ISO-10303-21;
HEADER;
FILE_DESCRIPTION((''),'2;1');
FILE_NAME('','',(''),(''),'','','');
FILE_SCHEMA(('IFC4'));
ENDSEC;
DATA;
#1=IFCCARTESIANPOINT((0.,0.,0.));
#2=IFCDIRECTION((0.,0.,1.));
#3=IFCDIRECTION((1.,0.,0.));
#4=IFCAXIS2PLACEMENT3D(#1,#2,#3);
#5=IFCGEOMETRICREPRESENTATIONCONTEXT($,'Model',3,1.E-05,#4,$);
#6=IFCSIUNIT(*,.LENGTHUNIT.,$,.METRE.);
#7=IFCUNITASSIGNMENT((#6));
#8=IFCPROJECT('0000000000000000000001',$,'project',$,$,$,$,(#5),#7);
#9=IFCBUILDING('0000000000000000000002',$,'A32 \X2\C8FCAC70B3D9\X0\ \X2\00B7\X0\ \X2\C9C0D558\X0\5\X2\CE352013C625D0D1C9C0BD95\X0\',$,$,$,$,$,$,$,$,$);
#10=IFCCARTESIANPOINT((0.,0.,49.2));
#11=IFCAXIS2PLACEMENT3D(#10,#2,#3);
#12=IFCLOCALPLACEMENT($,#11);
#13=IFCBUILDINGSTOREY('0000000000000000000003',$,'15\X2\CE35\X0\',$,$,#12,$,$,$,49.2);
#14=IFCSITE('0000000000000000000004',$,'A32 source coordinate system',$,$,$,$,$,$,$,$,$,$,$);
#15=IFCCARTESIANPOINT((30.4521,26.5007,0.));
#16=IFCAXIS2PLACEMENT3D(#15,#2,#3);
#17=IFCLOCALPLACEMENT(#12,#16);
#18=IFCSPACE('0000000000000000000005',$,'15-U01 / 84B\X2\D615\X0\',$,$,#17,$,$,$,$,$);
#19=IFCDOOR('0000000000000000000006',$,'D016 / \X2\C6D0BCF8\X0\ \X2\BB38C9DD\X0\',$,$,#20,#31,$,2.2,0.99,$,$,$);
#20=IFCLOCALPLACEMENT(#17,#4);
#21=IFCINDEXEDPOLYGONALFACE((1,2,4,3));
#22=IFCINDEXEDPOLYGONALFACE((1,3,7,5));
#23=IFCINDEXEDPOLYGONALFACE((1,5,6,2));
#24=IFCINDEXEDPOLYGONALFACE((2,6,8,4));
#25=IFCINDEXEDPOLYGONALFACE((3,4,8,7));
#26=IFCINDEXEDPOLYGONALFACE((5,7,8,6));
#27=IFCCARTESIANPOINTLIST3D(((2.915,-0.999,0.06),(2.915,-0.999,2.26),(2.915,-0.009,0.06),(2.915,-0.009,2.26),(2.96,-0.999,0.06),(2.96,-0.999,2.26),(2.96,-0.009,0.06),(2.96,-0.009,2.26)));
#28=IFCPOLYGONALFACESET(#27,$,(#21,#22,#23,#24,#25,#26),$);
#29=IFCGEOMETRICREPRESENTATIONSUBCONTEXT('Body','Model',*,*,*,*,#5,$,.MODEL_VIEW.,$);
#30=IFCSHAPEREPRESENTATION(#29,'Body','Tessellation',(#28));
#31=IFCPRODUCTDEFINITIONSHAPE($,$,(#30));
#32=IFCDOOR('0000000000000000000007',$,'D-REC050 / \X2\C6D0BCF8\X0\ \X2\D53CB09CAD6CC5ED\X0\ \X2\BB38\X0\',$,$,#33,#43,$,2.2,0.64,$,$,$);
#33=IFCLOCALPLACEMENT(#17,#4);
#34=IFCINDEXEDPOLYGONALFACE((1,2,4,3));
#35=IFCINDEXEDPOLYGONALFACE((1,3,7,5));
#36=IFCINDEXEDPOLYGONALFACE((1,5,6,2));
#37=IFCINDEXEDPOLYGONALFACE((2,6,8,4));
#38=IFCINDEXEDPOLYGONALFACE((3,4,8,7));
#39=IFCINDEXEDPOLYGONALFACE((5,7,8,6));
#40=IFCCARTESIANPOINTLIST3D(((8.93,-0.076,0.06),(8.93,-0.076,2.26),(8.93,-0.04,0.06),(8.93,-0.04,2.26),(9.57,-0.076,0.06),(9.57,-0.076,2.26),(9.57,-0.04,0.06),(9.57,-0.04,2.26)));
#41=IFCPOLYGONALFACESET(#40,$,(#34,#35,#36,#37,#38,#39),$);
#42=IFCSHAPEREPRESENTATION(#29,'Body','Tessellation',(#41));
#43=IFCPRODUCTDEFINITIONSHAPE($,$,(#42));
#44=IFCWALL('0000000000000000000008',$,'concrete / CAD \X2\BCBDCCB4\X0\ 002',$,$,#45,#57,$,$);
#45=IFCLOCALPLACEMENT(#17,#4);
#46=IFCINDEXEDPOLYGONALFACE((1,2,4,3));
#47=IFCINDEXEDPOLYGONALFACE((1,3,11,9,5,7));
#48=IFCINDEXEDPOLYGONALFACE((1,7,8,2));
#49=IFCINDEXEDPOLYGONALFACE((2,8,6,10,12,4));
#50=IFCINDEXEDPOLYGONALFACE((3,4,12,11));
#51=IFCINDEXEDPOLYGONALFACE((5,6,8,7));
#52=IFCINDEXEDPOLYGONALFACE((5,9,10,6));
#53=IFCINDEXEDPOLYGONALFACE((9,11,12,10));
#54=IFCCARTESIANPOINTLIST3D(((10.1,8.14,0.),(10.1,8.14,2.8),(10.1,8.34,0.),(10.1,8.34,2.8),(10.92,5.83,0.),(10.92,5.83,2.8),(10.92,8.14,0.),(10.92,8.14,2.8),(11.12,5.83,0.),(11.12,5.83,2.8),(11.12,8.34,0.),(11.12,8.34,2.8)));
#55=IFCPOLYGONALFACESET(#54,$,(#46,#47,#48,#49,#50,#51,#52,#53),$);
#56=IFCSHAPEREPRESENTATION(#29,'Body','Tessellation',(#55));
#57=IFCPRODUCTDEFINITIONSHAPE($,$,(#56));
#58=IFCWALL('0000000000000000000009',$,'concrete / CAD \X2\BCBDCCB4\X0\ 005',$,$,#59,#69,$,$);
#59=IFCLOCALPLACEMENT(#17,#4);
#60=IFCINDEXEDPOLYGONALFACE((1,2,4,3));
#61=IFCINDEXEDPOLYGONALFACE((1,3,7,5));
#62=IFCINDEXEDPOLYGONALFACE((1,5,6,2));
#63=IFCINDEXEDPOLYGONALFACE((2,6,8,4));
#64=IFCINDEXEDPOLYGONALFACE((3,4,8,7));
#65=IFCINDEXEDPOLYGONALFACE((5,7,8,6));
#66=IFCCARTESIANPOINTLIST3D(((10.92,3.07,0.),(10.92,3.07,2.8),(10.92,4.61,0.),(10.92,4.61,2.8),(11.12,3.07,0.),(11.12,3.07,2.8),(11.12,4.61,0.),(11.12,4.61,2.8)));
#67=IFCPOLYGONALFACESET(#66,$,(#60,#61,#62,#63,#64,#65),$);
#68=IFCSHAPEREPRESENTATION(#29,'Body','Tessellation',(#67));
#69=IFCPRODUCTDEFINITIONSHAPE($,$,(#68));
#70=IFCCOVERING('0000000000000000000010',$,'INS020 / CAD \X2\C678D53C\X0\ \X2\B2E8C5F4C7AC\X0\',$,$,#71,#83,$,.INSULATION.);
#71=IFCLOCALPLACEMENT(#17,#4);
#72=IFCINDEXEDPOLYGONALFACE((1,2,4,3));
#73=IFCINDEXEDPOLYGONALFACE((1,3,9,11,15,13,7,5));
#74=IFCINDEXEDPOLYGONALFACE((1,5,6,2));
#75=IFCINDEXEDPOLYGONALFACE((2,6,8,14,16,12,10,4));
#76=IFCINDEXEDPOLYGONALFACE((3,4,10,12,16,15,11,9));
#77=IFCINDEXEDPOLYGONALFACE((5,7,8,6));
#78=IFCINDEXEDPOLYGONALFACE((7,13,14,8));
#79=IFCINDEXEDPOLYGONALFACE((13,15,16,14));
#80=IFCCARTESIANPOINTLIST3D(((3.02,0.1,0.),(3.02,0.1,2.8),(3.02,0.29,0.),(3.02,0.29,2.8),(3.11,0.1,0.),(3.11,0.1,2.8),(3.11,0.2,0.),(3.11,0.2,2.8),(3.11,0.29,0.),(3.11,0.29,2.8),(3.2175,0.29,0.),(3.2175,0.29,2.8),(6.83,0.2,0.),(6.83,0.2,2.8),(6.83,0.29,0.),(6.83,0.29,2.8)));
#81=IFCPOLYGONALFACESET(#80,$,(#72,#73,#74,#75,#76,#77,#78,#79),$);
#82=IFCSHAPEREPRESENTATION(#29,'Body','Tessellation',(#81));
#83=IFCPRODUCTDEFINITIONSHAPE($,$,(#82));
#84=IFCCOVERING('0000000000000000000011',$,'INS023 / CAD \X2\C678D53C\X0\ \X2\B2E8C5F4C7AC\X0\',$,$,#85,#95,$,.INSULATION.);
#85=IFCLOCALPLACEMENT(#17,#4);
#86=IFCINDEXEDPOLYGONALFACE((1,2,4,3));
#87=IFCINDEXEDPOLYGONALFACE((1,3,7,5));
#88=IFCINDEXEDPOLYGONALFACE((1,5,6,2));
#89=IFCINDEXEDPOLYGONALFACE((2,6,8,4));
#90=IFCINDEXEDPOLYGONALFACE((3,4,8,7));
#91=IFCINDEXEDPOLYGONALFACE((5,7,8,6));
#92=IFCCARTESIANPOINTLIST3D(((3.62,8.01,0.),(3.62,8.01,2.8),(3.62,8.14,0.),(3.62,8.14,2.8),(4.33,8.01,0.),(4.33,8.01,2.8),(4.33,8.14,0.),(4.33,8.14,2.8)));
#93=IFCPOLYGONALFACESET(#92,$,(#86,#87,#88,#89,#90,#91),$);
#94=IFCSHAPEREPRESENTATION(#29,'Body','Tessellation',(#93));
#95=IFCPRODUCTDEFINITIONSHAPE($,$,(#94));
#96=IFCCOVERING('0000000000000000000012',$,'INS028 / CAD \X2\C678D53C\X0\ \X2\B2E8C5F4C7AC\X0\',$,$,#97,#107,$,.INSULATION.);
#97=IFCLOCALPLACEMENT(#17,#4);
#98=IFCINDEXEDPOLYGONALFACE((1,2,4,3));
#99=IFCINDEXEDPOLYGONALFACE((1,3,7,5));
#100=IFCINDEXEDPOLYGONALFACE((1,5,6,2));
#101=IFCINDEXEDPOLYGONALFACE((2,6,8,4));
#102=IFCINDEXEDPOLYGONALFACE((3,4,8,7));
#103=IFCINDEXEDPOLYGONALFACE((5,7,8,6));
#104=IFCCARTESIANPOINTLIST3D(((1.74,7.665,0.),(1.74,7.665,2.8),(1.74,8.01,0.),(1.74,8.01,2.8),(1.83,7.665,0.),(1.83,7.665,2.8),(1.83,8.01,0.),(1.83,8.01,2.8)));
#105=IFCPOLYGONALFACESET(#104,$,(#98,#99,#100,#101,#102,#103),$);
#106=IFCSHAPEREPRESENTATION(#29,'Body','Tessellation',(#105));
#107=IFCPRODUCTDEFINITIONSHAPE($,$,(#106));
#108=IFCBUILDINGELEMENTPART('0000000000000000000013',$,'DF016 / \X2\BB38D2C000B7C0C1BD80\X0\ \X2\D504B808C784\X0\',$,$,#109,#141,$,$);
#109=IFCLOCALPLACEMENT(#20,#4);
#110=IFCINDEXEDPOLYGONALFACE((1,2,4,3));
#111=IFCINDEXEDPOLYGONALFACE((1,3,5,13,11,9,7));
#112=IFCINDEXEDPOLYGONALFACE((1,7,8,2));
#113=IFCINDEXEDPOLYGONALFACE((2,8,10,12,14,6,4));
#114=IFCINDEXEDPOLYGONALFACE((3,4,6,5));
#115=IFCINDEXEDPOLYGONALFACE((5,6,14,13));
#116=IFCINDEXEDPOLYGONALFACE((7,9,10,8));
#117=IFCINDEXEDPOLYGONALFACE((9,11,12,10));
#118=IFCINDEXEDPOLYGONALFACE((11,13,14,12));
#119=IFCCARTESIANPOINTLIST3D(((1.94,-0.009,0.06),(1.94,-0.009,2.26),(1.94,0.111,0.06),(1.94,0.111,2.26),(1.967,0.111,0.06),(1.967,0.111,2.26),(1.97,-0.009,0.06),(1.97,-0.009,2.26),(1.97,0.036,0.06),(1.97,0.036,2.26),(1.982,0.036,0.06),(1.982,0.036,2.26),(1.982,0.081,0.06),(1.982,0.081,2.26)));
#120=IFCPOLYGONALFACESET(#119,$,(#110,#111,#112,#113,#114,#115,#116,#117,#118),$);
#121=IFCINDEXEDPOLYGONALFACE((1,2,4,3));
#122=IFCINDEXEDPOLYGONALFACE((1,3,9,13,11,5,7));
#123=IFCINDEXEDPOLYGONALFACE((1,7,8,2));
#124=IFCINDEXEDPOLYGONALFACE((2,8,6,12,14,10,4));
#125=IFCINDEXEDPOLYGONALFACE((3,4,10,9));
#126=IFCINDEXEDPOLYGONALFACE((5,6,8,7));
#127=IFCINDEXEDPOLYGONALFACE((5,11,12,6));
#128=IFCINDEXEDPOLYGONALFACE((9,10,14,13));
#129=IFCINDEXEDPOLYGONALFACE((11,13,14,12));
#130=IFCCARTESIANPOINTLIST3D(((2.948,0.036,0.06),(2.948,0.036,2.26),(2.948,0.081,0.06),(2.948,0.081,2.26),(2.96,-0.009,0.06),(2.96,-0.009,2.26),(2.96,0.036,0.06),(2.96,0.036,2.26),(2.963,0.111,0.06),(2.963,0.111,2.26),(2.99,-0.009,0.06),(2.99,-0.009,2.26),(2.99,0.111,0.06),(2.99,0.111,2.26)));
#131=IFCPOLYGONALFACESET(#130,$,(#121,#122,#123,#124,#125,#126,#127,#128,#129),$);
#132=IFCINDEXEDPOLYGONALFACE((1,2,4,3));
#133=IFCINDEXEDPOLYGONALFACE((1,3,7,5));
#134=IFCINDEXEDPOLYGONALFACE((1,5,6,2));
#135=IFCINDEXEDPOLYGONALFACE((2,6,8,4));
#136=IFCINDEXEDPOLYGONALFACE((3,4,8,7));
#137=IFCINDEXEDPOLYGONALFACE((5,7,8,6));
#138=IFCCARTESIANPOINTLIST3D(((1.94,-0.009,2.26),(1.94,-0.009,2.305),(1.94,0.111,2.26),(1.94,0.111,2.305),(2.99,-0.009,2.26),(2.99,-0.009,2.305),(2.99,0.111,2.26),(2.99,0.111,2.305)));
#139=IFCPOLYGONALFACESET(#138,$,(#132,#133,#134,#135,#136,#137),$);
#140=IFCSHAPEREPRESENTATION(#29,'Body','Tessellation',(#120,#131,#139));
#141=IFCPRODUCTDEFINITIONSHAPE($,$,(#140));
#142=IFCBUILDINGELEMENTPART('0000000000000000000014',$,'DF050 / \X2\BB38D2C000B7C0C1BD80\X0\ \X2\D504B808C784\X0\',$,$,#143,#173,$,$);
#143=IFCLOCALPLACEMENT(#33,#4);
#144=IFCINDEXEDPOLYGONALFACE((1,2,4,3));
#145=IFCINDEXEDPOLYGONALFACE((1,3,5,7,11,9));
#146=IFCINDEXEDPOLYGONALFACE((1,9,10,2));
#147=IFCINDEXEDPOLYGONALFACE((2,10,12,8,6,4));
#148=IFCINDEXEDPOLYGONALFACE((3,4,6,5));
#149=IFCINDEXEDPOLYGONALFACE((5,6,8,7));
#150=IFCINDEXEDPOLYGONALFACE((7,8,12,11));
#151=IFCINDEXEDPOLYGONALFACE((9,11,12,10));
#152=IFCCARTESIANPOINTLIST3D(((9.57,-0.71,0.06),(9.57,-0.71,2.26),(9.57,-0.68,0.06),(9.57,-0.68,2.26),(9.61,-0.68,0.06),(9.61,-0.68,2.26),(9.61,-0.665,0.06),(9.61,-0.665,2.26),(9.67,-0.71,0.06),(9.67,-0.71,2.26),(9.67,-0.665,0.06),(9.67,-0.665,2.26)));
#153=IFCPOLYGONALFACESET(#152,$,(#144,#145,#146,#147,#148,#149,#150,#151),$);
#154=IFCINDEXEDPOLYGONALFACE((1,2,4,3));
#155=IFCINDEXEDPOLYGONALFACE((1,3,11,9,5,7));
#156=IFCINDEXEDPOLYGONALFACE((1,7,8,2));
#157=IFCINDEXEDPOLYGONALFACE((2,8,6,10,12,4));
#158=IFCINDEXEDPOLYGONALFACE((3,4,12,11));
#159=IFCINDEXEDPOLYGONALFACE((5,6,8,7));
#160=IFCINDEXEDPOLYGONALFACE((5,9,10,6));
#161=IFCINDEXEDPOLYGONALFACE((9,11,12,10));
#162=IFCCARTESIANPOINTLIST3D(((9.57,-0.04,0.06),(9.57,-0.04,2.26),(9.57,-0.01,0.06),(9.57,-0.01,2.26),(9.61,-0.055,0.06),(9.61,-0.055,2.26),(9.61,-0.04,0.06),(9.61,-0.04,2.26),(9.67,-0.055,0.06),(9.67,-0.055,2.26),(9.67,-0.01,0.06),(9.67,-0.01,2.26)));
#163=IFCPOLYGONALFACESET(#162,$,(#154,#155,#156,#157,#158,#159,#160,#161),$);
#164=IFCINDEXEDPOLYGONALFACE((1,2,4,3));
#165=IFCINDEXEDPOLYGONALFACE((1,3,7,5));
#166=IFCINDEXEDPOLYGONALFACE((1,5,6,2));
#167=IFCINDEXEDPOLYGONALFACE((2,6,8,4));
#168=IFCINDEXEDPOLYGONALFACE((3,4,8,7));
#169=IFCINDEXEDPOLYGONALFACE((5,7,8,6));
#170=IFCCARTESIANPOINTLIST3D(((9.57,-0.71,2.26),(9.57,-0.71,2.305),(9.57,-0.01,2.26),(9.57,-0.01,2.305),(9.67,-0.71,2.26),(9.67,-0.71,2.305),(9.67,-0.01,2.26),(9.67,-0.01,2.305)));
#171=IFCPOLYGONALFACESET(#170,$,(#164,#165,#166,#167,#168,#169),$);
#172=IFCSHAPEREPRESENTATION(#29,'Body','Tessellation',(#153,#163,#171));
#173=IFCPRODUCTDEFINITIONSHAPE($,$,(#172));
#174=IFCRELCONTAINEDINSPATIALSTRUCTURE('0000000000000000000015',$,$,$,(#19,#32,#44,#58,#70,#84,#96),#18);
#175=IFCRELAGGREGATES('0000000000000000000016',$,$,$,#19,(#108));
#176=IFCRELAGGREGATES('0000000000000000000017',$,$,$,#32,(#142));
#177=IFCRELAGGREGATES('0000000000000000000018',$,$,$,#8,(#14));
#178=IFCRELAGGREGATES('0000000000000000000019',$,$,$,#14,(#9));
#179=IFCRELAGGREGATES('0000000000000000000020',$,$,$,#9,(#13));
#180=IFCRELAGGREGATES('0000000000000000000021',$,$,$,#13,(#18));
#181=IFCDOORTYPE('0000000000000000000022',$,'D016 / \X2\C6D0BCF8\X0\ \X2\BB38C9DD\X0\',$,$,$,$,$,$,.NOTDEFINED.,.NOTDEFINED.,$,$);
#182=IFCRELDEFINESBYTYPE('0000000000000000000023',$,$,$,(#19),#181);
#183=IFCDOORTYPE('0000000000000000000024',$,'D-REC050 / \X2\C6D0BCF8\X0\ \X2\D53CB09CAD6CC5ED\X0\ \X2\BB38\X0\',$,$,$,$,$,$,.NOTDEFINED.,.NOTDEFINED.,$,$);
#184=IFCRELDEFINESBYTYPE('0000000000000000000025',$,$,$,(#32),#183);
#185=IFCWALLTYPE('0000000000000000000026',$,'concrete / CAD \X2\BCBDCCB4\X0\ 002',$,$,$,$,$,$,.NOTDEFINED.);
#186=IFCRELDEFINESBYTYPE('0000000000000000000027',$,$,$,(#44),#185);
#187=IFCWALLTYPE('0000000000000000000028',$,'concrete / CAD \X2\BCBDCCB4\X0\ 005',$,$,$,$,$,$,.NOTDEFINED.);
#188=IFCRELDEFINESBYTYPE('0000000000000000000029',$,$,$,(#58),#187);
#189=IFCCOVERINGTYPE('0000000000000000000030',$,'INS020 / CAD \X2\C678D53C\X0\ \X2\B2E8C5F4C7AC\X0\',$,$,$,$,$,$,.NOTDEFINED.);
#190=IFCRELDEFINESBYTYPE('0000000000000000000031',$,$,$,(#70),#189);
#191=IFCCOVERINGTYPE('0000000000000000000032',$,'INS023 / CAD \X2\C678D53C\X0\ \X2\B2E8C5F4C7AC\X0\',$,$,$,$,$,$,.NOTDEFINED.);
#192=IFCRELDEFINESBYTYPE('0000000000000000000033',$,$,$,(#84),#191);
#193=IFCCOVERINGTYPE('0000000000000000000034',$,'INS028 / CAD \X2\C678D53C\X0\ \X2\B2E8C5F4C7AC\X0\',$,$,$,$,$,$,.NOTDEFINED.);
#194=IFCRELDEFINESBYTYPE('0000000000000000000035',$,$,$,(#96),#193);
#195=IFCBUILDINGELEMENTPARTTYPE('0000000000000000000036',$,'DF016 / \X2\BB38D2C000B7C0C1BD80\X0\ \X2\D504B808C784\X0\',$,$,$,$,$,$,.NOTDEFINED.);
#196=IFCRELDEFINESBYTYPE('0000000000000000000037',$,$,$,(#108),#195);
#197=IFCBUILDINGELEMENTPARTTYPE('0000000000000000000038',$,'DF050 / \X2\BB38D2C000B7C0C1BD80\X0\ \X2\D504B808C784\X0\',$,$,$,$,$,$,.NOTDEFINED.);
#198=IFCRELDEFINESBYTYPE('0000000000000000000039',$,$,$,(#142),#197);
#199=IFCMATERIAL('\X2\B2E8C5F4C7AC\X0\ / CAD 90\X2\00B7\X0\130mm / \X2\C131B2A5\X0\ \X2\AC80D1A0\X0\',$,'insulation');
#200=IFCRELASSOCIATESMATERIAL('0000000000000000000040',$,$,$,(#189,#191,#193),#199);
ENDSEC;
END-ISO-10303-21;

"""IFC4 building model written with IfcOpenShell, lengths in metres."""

from ifc_helpers import new_model, si_unit, frame, origin, origin_with_axes, place, context, subcontext, project, spatial, polyline, outline, extrude, source, transform, mapped, material, type_object, type_shapes, element, aggregate, save


model = new_model("IFC4")

# Units and contexts
model_context = context("Model", 3, precision=1e-05, world=origin_with_axes())
body_context = subcontext(model_context, "Body", "Model", "MODEL_VIEW")
ifc_project = project(units=[si_unit("LENGTHUNIT", "METRE")], contexts=[model_context])

# Site, building, storey, space
storey_placement = place(None, frame((0.0, 0.0, 49.2), z_axis=(0.0, 0.0, 1.0), x_axis=(1.0, 0.0, 0.0)))
space_placement = place(storey_placement, frame((30.4521, 26.5007, 0.0), z_axis=(0.0, 0.0, 1.0), x_axis=(1.0, 0.0, 0.0)))
site = spatial("IfcSite", under=ifc_project, Name="A32 source coordinate system")
building = spatial("IfcBuilding", under=site, Name="A32 주거동 · 지하5층–옥탑지붕")
storey = spatial("IfcBuildingStorey", under=building, at=storey_placement, Name="15층", Elevation=49.2)
space = spatial("IfcSpace", under=storey, at=space_placement, Name="15-U01 / 84B형")

# Doors
door_type_1 = type_object("IfcDoorType", Name="D016 / 원본 문짝", OperationType="NOTDEFINED", PredefinedType="NOTDEFINED")
shared_shape_1 = source(origin(), body_context, "Body", "SweptSolid", [
    extrude(outline(polyline([(2.96, -0.009), (2.96, -0.999), (2.915, -0.999), (2.915, -0.009), (2.96, -0.009)])), frame((0.0, 0.0, 0.06)), (0.0, 0.0, 1.0), 2.2),
])
type_shapes(door_type_1, [shared_shape_1])
door_1_placement = place(space_placement, origin_with_axes())
door_1 = element("IfcDoor", 1, at=door_1_placement, inside=space, type_object=door_type_1, Name="D016 / 원본 문짝", OverallHeight=2.2, OverallWidth=0.99, context=body_context, shape_type="MappedRepresentation", body=[
    mapped(shared_shape_1, transform((0.0, 0.0, 0.0), scale=1.0)),
])
door_type_2 = type_object("IfcDoorType", Name="D-REC050 / 원본 피난구역 문", OperationType="NOTDEFINED", PredefinedType="NOTDEFINED")
shared_shape_2 = source(origin(), body_context, "Body", "SweptSolid", [
    extrude(outline(polyline([(9.57, -0.04), (9.57, -0.076), (8.93, -0.076), (8.93, -0.04), (9.57, -0.04)])), frame((0.0, 0.0, 0.06)), (0.0, 0.0, 1.0), 2.2),
])
type_shapes(door_type_2, [shared_shape_2])
door_2_placement = place(space_placement, origin_with_axes())
door_2 = element("IfcDoor", 2, at=door_2_placement, inside=space, type_object=door_type_2, Name="D-REC050 / 원본 피난구역 문", OverallHeight=2.2, OverallWidth=0.64, context=body_context, shape_type="MappedRepresentation", body=[
    mapped(shared_shape_2, transform((0.0, 0.0, 0.0), scale=1.0)),
])

# Walls
wall_type_1 = type_object("IfcWallType", Name="concrete / CAD 벽체 002", PredefinedType="NOTDEFINED")
shared_shape_3 = source(origin(), body_context, "Body", "SweptSolid", [
    extrude(outline(polyline([(11.12, 5.83), (10.92, 5.83), (10.92, 8.14), (10.1, 8.14), (10.1, 8.34), (11.12, 8.34), (11.12, 5.83)])), origin(), (0.0, 0.0, 1.0), 2.8),
])
type_shapes(wall_type_1, [shared_shape_3])
wall_1_placement = place(space_placement, origin_with_axes())
element("IfcWall", 3, at=wall_1_placement, inside=space, type_object=wall_type_1, Name="concrete / CAD 벽체 002", context=body_context, shape_type="MappedRepresentation", body=[
    mapped(shared_shape_3, transform((0.0, 0.0, 0.0), scale=1.0)),
])
wall_type_2 = type_object("IfcWallType", Name="concrete / CAD 벽체 005", PredefinedType="NOTDEFINED")
shared_shape_4 = source(origin(), body_context, "Body", "SweptSolid", [
    extrude(outline(polyline([(11.12, 3.07), (10.92, 3.07), (10.92, 4.61), (11.12, 4.61), (11.12, 3.07)])), origin(), (0.0, 0.0, 1.0), 2.8),
])
type_shapes(wall_type_2, [shared_shape_4])
wall_2_placement = place(space_placement, origin_with_axes())
element("IfcWall", 4, at=wall_2_placement, inside=space, type_object=wall_type_2, Name="concrete / CAD 벽체 005", context=body_context, shape_type="MappedRepresentation", body=[
    mapped(shared_shape_4, transform((0.0, 0.0, 0.0), scale=1.0)),
])

# Coverings
ifc_material = material(Name="단열재 / CAD 90·130mm / 성능 검토", Category="insulation")
covering_type_1 = type_object("IfcCoveringType", Name="INS020 / CAD 외피 단열재", PredefinedType="NOTDEFINED", material=ifc_material)
shared_shape_5 = source(origin(), body_context, "Body", "SweptSolid", [
    extrude(outline(polyline([(3.11, 0.2), (3.11, 0.1), (3.02, 0.1), (3.02, 0.29), (3.11, 0.29), (3.2175, 0.29), (6.83, 0.29), (6.83, 0.2), (3.11, 0.2)])), origin(), (0.0, 0.0, 1.0), 2.8),
])
type_shapes(covering_type_1, [shared_shape_5])
covering_1_placement = place(space_placement, origin_with_axes())
element("IfcCovering", 5, at=covering_1_placement, inside=space, type_object=covering_type_1, Name="INS020 / CAD 외피 단열재", PredefinedType="INSULATION", context=body_context, shape_type="MappedRepresentation", body=[
    mapped(shared_shape_5, transform((0.0, 0.0, 0.0), scale=1.0)),
])
covering_type_2 = type_object("IfcCoveringType", Name="INS023 / CAD 외피 단열재", PredefinedType="NOTDEFINED", material=ifc_material)
shared_shape_6 = source(origin(), body_context, "Body", "SweptSolid", [
    extrude(outline(polyline([(4.33, 8.01), (3.62, 8.01), (3.62, 8.14), (4.33, 8.14), (4.33, 8.01)])), origin(), (0.0, 0.0, 1.0), 2.8),
])
type_shapes(covering_type_2, [shared_shape_6])
covering_2_placement = place(space_placement, origin_with_axes())
element("IfcCovering", 6, at=covering_2_placement, inside=space, type_object=covering_type_2, Name="INS023 / CAD 외피 단열재", PredefinedType="INSULATION", context=body_context, shape_type="MappedRepresentation", body=[
    mapped(shared_shape_6, transform((0.0, 0.0, 0.0), scale=1.0)),
])
covering_type_3 = type_object("IfcCoveringType", Name="INS028 / CAD 외피 단열재", PredefinedType="NOTDEFINED", material=ifc_material)
shared_shape_7 = source(origin(), body_context, "Body", "SweptSolid", [
    extrude(outline(polyline([(1.74, 8.01), (1.83, 8.01), (1.83, 7.665), (1.74, 7.665), (1.74, 8.01)])), origin(), (0.0, 0.0, 1.0), 2.8),
])
type_shapes(covering_type_3, [shared_shape_7])
covering_3_placement = place(space_placement, origin_with_axes())
element("IfcCovering", 7, at=covering_3_placement, inside=space, type_object=covering_type_3, Name="INS028 / CAD 외피 단열재", PredefinedType="INSULATION", context=body_context, shape_type="MappedRepresentation", body=[
    mapped(shared_shape_7, transform((0.0, 0.0, 0.0), scale=1.0)),
])

# Building element parts
building_element_part_type_1 = type_object("IfcBuildingElementPartType", Name="DF016 / 문틀·상부 프레임", PredefinedType="NOTDEFINED")
shared_shape_8 = source(origin(), body_context, "Body", "SweptSolid", [
    extrude(outline(polyline([(1.94, 0.111), (1.967, 0.111), (1.982, 0.081), (1.982, 0.036), (1.97, 0.036), (1.97, -0.009), (1.94, -0.009), (1.94, 0.111)])), frame((0.0, 0.0, 0.06)), (0.0, 0.0, 1.0), 2.2),
    extrude(outline(polyline([(2.96, -0.009), (2.96, 0.036), (2.948, 0.036), (2.948, 0.081), (2.963, 0.111), (2.99, 0.111), (2.99, -0.009), (2.96, -0.009)])), frame((0.0, 0.0, 0.06)), (0.0, 0.0, 1.0), 2.2),
    extrude(outline(polyline([(1.94, -0.009), (1.94, 0.111), (2.99, 0.111), (2.99, -0.009), (1.94, -0.009)])), frame((0.0, 0.0, 2.26)), (0.0, 0.0, 1.0), 0.045),
])
type_shapes(building_element_part_type_1, [shared_shape_8])
building_element_part_1_placement = place(door_1_placement, origin_with_axes())
building_element_part_1 = element("IfcBuildingElementPart", 8, at=building_element_part_1_placement, type_object=building_element_part_type_1, Name="DF016 / 문틀·상부 프레임", context=body_context, shape_type="MappedRepresentation", body=[
    mapped(shared_shape_8, transform((0.0, 0.0, 0.0), scale=1.0)),
])
aggregate(door_1, [building_element_part_1])
building_element_part_type_2 = type_object("IfcBuildingElementPartType", Name="DF050 / 문틀·상부 프레임", PredefinedType="NOTDEFINED")
shared_shape_9 = source(origin(), body_context, "Body", "SweptSolid", [
    extrude(outline(polyline([(9.57, -0.68), (9.61, -0.68), (9.61, -0.665), (9.67, -0.665), (9.67, -0.71), (9.57, -0.71), (9.57, -0.68)])), frame((0.0, 0.0, 0.06)), (0.0, 0.0, 1.0), 2.2),
    extrude(outline(polyline([(9.67, -0.01), (9.67, -0.055), (9.61, -0.055), (9.61, -0.04), (9.57, -0.04), (9.57, -0.01), (9.67, -0.01)])), frame((0.0, 0.0, 0.06)), (0.0, 0.0, 1.0), 2.2),
    extrude(outline(polyline([(9.57, -0.71), (9.57, -0.01), (9.67, -0.01), (9.67, -0.71), (9.57, -0.71)])), frame((0.0, 0.0, 2.26)), (0.0, 0.0, 1.0), 0.045),
])
type_shapes(building_element_part_type_2, [shared_shape_9])
building_element_part_2_placement = place(door_2_placement, origin_with_axes())
building_element_part_2 = element("IfcBuildingElementPart", 9, at=building_element_part_2_placement, type_object=building_element_part_type_2, Name="DF050 / 문틀·상부 프레임", context=body_context, shape_type="MappedRepresentation", body=[
    mapped(shared_shape_9, transform((0.0, 0.0, 0.0), scale=1.0)),
])
aggregate(door_2, [building_element_part_2])

save(model, "model.ifc")
